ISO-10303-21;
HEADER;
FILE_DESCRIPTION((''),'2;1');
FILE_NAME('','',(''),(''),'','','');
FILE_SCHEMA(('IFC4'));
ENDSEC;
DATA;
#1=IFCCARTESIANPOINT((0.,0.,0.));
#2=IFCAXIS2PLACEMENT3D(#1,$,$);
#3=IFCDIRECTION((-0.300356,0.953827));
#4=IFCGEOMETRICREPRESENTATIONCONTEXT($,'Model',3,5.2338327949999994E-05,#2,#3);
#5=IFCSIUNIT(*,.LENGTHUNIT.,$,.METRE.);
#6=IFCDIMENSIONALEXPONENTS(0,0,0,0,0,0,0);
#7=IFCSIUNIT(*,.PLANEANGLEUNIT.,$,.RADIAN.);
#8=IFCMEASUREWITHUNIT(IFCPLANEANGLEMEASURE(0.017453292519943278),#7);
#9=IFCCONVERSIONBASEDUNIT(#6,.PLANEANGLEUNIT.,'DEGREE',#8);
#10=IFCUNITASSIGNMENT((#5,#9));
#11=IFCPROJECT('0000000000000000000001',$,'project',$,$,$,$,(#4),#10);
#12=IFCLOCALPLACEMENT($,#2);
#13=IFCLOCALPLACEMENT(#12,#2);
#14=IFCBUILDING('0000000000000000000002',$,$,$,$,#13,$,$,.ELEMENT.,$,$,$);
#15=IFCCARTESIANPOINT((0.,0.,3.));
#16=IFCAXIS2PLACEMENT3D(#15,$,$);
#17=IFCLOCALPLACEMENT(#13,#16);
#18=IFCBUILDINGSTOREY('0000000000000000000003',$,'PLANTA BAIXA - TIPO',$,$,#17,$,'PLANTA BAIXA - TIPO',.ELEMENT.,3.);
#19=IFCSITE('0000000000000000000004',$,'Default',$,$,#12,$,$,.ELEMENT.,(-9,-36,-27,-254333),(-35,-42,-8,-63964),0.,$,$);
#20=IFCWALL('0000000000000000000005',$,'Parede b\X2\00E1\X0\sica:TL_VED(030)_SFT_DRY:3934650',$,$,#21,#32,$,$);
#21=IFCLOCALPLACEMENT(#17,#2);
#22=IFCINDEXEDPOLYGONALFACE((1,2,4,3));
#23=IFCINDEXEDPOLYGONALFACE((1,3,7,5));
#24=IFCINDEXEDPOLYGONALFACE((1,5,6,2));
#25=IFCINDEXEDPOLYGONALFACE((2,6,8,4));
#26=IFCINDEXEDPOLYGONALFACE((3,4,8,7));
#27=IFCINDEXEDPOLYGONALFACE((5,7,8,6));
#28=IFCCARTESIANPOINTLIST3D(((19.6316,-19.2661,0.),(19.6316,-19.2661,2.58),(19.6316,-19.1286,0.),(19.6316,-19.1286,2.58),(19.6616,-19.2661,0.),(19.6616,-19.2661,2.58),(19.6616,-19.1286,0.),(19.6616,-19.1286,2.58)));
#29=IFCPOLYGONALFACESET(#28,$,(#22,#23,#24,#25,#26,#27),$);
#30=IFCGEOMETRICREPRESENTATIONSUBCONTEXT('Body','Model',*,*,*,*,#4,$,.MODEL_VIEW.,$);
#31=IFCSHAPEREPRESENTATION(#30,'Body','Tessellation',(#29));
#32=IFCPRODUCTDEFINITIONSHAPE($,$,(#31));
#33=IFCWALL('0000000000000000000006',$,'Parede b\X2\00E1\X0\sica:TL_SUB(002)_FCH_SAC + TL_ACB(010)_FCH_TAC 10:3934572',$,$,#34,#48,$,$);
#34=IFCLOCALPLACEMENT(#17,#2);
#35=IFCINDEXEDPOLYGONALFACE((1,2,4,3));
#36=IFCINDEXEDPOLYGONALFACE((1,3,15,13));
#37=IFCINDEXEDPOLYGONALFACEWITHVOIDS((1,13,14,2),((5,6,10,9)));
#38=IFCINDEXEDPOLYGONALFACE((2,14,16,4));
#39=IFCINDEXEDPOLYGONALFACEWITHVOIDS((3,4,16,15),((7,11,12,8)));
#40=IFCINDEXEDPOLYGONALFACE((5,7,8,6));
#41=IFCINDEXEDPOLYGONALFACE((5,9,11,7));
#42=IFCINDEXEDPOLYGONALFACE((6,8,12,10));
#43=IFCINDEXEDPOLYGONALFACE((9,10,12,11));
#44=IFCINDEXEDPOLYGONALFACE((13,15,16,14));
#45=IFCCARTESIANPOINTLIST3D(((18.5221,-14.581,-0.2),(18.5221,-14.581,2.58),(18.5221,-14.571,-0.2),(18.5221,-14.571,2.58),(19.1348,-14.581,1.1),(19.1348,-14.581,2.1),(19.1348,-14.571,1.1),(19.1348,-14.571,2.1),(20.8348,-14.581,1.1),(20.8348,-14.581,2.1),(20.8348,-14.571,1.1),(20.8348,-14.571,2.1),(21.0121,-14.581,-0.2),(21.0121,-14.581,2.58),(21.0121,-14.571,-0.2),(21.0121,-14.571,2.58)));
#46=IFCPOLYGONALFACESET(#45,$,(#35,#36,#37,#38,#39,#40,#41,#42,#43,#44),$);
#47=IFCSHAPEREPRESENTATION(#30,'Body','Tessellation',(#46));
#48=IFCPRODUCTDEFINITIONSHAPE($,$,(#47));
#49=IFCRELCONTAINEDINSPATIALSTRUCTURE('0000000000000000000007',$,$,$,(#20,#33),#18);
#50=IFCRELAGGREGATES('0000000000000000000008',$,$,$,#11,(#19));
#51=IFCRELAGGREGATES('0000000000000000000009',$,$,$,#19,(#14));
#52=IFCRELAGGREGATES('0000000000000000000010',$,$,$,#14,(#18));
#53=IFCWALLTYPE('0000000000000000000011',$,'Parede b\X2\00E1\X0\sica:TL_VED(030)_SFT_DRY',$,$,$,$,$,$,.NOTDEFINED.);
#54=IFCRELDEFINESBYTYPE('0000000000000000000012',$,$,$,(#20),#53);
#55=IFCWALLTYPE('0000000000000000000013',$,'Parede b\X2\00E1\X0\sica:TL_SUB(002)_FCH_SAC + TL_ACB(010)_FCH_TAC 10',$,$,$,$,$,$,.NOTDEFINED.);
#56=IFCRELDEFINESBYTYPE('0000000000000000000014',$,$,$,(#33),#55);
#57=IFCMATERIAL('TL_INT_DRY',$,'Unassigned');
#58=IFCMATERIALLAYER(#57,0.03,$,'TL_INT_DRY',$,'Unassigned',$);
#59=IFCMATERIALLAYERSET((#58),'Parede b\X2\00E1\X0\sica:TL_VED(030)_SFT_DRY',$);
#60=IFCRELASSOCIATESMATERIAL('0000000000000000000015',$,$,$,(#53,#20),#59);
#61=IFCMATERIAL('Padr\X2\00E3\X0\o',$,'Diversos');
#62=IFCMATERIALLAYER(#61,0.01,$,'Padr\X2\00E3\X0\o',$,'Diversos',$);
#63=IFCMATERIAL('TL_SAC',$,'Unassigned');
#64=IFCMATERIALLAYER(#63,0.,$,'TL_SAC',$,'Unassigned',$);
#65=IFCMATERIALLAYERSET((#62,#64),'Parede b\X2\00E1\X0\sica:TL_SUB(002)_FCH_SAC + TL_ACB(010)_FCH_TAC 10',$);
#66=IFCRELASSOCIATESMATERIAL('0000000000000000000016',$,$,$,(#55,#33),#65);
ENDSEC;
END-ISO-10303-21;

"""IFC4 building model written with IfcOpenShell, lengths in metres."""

from ifc_helpers import new_model, entity, si_unit, converted_unit, direction, frame, frame_2d, origin, place, context, subcontext, project, spatial, rectangle, extrude, material, layer, layer_set, layer_usage, type_object, element, save


model = new_model("IFC4")

# Units and contexts
model_context = context("Model", 3, precision=5.2338327949999994e-05, world=origin(), true_north=direction((-0.300356, 0.953827)))
body_context = subcontext(model_context, "Body", "Model", "MODEL_VIEW")
ifc_project = project(units=[si_unit("LENGTHUNIT", "METRE"), converted_unit("PLANEANGLEUNIT", "DEGREE", entity("IfcPlaneAngleMeasure", 0.017453292519943278), si_unit("PLANEANGLEUNIT", "RADIAN"), dimensions=[0, 0, 0, 0, 0, 0, 0])], contexts=[model_context])

# Site, building, storey
site_placement = place(None, origin())
site = spatial("IfcSite", under=ifc_project, at=site_placement, Name="Default", CompositionType="ELEMENT", RefLatitude=(-9, -36, -27, -254333), RefLongitude=(-35, -42, -8, -63964), RefElevation=0.0)
building_placement = place(site_placement, origin())
building = spatial("IfcBuilding", under=site, at=building_placement, CompositionType="ELEMENT")
storey_placement = place(building_placement, frame((0.0, 0.0, 3.0)))
storey = spatial("IfcBuildingStorey", under=building, at=storey_placement, Name="PLANTA BAIXA - TIPO", LongName="PLANTA BAIXA - TIPO", CompositionType="ELEMENT", Elevation=3.0)

# Shared definitions
ifc_material_1 = material(Name="TL_SAC", Category="Unassigned")

# Wall
ifc_material_2 = material(Name="TL_INT_DRY", Category="Unassigned")
ifc_layer_1 = layer(ifc_material_2, 0.03, Name="TL_INT_DRY", Category="Unassigned")
ifc_layer_set_1 = layer_set([ifc_layer_1], Name="Parede básica:TL_VED(030)_SFT_DRY")
wall_type_1 = type_object("IfcWallType", Name="Parede básica:TL_VED(030)_SFT_DRY", PredefinedType="NOTDEFINED", material=ifc_layer_set_1)
ifc_layer_usage_1 = layer_usage(ifc_layer_set_1, "AXIS2", "POSITIVE", -0.015)
wall_1_placement = place(storey_placement, frame((19.6466, -19.1286, 0.0), z_axis=(0.0, 0.0, 1.0), x_axis=(0.0, -1.0, 0.0)))
element("IfcWall", 1, at=wall_1_placement, inside=storey, type_object=wall_type_1, material=ifc_layer_usage_1, Name="Parede básica:TL_VED(030)_SFT_DRY:3934650", context=body_context, shape_type="SweptSolid", body=[
    extrude(rectangle(XDim=0.1375, YDim=0.03, at=frame_2d((0.0688, 0.0), x_axis=(-1.0, 0.0))), origin(), (0.0, 0.0, 1.0), 2.58),
])

# Wall, opening
ifc_material_3 = material(Name="Padrão", Category="Diversos")
ifc_layer_2 = layer(ifc_material_3, 0.01, Name="Padrão", Category="Diversos")
ifc_layer_3 = layer(ifc_material_1, 0.0, Name="TL_SAC", Category="Unassigned")
ifc_layer_set_2 = layer_set([ifc_layer_2, ifc_layer_3], Name="Parede básica:TL_SUB(002)_FCH_SAC + TL_ACB(010)_FCH_TAC 10")
ifc_layer_usage_2 = layer_usage(ifc_layer_set_2, "AXIS2", "POSITIVE", -0.005)
wall_type_2 = type_object("IfcWallType", Name="Parede básica:TL_SUB(002)_FCH_SAC + TL_ACB(010)_FCH_TAC 10", PredefinedType="NOTDEFINED", material=ifc_layer_set_2)
wall_2_placement = place(storey_placement, frame((18.5221, -14.576, -0.2)))
wall_2 = element("IfcWall", 2, at=wall_2_placement, inside=storey, type_object=wall_type_2, material=ifc_layer_usage_2, Name="Parede básica:TL_SUB(002)_FCH_SAC + TL_ACB(010)_FCH_TAC 10:3934572", context=body_context, shape_type="SweptSolid", body=[
    extrude(rectangle(XDim=2.49, YDim=0.01, at=frame_2d((1.245, 0.0), x_axis=(-1.0, 0.0))), origin(), (0.0, 0.0, 1.0), 2.78),
])
opening_1_placement = place(wall_2_placement, frame((-18.5221, 14.576, 1.3)))
element("IfcOpeningElement", 3, at=opening_1_placement, cuts=wall_2, PredefinedType="OPENING", context=body_context, shape_type="SweptSolid", body=[
    extrude(rectangle(XDim=1.0, YDim=1.7, at=frame_2d((0.0, 0.0), x_axis=(0.0, 1.0))), frame((19.9848, -16.205, 0.5), z_axis=(0.0, 1.0, 0.0), x_axis=(1.0, 0.0, 0.0)), (0.0, 0.0, 1.0), 3.048),
])

save(model, "model.ifc")
